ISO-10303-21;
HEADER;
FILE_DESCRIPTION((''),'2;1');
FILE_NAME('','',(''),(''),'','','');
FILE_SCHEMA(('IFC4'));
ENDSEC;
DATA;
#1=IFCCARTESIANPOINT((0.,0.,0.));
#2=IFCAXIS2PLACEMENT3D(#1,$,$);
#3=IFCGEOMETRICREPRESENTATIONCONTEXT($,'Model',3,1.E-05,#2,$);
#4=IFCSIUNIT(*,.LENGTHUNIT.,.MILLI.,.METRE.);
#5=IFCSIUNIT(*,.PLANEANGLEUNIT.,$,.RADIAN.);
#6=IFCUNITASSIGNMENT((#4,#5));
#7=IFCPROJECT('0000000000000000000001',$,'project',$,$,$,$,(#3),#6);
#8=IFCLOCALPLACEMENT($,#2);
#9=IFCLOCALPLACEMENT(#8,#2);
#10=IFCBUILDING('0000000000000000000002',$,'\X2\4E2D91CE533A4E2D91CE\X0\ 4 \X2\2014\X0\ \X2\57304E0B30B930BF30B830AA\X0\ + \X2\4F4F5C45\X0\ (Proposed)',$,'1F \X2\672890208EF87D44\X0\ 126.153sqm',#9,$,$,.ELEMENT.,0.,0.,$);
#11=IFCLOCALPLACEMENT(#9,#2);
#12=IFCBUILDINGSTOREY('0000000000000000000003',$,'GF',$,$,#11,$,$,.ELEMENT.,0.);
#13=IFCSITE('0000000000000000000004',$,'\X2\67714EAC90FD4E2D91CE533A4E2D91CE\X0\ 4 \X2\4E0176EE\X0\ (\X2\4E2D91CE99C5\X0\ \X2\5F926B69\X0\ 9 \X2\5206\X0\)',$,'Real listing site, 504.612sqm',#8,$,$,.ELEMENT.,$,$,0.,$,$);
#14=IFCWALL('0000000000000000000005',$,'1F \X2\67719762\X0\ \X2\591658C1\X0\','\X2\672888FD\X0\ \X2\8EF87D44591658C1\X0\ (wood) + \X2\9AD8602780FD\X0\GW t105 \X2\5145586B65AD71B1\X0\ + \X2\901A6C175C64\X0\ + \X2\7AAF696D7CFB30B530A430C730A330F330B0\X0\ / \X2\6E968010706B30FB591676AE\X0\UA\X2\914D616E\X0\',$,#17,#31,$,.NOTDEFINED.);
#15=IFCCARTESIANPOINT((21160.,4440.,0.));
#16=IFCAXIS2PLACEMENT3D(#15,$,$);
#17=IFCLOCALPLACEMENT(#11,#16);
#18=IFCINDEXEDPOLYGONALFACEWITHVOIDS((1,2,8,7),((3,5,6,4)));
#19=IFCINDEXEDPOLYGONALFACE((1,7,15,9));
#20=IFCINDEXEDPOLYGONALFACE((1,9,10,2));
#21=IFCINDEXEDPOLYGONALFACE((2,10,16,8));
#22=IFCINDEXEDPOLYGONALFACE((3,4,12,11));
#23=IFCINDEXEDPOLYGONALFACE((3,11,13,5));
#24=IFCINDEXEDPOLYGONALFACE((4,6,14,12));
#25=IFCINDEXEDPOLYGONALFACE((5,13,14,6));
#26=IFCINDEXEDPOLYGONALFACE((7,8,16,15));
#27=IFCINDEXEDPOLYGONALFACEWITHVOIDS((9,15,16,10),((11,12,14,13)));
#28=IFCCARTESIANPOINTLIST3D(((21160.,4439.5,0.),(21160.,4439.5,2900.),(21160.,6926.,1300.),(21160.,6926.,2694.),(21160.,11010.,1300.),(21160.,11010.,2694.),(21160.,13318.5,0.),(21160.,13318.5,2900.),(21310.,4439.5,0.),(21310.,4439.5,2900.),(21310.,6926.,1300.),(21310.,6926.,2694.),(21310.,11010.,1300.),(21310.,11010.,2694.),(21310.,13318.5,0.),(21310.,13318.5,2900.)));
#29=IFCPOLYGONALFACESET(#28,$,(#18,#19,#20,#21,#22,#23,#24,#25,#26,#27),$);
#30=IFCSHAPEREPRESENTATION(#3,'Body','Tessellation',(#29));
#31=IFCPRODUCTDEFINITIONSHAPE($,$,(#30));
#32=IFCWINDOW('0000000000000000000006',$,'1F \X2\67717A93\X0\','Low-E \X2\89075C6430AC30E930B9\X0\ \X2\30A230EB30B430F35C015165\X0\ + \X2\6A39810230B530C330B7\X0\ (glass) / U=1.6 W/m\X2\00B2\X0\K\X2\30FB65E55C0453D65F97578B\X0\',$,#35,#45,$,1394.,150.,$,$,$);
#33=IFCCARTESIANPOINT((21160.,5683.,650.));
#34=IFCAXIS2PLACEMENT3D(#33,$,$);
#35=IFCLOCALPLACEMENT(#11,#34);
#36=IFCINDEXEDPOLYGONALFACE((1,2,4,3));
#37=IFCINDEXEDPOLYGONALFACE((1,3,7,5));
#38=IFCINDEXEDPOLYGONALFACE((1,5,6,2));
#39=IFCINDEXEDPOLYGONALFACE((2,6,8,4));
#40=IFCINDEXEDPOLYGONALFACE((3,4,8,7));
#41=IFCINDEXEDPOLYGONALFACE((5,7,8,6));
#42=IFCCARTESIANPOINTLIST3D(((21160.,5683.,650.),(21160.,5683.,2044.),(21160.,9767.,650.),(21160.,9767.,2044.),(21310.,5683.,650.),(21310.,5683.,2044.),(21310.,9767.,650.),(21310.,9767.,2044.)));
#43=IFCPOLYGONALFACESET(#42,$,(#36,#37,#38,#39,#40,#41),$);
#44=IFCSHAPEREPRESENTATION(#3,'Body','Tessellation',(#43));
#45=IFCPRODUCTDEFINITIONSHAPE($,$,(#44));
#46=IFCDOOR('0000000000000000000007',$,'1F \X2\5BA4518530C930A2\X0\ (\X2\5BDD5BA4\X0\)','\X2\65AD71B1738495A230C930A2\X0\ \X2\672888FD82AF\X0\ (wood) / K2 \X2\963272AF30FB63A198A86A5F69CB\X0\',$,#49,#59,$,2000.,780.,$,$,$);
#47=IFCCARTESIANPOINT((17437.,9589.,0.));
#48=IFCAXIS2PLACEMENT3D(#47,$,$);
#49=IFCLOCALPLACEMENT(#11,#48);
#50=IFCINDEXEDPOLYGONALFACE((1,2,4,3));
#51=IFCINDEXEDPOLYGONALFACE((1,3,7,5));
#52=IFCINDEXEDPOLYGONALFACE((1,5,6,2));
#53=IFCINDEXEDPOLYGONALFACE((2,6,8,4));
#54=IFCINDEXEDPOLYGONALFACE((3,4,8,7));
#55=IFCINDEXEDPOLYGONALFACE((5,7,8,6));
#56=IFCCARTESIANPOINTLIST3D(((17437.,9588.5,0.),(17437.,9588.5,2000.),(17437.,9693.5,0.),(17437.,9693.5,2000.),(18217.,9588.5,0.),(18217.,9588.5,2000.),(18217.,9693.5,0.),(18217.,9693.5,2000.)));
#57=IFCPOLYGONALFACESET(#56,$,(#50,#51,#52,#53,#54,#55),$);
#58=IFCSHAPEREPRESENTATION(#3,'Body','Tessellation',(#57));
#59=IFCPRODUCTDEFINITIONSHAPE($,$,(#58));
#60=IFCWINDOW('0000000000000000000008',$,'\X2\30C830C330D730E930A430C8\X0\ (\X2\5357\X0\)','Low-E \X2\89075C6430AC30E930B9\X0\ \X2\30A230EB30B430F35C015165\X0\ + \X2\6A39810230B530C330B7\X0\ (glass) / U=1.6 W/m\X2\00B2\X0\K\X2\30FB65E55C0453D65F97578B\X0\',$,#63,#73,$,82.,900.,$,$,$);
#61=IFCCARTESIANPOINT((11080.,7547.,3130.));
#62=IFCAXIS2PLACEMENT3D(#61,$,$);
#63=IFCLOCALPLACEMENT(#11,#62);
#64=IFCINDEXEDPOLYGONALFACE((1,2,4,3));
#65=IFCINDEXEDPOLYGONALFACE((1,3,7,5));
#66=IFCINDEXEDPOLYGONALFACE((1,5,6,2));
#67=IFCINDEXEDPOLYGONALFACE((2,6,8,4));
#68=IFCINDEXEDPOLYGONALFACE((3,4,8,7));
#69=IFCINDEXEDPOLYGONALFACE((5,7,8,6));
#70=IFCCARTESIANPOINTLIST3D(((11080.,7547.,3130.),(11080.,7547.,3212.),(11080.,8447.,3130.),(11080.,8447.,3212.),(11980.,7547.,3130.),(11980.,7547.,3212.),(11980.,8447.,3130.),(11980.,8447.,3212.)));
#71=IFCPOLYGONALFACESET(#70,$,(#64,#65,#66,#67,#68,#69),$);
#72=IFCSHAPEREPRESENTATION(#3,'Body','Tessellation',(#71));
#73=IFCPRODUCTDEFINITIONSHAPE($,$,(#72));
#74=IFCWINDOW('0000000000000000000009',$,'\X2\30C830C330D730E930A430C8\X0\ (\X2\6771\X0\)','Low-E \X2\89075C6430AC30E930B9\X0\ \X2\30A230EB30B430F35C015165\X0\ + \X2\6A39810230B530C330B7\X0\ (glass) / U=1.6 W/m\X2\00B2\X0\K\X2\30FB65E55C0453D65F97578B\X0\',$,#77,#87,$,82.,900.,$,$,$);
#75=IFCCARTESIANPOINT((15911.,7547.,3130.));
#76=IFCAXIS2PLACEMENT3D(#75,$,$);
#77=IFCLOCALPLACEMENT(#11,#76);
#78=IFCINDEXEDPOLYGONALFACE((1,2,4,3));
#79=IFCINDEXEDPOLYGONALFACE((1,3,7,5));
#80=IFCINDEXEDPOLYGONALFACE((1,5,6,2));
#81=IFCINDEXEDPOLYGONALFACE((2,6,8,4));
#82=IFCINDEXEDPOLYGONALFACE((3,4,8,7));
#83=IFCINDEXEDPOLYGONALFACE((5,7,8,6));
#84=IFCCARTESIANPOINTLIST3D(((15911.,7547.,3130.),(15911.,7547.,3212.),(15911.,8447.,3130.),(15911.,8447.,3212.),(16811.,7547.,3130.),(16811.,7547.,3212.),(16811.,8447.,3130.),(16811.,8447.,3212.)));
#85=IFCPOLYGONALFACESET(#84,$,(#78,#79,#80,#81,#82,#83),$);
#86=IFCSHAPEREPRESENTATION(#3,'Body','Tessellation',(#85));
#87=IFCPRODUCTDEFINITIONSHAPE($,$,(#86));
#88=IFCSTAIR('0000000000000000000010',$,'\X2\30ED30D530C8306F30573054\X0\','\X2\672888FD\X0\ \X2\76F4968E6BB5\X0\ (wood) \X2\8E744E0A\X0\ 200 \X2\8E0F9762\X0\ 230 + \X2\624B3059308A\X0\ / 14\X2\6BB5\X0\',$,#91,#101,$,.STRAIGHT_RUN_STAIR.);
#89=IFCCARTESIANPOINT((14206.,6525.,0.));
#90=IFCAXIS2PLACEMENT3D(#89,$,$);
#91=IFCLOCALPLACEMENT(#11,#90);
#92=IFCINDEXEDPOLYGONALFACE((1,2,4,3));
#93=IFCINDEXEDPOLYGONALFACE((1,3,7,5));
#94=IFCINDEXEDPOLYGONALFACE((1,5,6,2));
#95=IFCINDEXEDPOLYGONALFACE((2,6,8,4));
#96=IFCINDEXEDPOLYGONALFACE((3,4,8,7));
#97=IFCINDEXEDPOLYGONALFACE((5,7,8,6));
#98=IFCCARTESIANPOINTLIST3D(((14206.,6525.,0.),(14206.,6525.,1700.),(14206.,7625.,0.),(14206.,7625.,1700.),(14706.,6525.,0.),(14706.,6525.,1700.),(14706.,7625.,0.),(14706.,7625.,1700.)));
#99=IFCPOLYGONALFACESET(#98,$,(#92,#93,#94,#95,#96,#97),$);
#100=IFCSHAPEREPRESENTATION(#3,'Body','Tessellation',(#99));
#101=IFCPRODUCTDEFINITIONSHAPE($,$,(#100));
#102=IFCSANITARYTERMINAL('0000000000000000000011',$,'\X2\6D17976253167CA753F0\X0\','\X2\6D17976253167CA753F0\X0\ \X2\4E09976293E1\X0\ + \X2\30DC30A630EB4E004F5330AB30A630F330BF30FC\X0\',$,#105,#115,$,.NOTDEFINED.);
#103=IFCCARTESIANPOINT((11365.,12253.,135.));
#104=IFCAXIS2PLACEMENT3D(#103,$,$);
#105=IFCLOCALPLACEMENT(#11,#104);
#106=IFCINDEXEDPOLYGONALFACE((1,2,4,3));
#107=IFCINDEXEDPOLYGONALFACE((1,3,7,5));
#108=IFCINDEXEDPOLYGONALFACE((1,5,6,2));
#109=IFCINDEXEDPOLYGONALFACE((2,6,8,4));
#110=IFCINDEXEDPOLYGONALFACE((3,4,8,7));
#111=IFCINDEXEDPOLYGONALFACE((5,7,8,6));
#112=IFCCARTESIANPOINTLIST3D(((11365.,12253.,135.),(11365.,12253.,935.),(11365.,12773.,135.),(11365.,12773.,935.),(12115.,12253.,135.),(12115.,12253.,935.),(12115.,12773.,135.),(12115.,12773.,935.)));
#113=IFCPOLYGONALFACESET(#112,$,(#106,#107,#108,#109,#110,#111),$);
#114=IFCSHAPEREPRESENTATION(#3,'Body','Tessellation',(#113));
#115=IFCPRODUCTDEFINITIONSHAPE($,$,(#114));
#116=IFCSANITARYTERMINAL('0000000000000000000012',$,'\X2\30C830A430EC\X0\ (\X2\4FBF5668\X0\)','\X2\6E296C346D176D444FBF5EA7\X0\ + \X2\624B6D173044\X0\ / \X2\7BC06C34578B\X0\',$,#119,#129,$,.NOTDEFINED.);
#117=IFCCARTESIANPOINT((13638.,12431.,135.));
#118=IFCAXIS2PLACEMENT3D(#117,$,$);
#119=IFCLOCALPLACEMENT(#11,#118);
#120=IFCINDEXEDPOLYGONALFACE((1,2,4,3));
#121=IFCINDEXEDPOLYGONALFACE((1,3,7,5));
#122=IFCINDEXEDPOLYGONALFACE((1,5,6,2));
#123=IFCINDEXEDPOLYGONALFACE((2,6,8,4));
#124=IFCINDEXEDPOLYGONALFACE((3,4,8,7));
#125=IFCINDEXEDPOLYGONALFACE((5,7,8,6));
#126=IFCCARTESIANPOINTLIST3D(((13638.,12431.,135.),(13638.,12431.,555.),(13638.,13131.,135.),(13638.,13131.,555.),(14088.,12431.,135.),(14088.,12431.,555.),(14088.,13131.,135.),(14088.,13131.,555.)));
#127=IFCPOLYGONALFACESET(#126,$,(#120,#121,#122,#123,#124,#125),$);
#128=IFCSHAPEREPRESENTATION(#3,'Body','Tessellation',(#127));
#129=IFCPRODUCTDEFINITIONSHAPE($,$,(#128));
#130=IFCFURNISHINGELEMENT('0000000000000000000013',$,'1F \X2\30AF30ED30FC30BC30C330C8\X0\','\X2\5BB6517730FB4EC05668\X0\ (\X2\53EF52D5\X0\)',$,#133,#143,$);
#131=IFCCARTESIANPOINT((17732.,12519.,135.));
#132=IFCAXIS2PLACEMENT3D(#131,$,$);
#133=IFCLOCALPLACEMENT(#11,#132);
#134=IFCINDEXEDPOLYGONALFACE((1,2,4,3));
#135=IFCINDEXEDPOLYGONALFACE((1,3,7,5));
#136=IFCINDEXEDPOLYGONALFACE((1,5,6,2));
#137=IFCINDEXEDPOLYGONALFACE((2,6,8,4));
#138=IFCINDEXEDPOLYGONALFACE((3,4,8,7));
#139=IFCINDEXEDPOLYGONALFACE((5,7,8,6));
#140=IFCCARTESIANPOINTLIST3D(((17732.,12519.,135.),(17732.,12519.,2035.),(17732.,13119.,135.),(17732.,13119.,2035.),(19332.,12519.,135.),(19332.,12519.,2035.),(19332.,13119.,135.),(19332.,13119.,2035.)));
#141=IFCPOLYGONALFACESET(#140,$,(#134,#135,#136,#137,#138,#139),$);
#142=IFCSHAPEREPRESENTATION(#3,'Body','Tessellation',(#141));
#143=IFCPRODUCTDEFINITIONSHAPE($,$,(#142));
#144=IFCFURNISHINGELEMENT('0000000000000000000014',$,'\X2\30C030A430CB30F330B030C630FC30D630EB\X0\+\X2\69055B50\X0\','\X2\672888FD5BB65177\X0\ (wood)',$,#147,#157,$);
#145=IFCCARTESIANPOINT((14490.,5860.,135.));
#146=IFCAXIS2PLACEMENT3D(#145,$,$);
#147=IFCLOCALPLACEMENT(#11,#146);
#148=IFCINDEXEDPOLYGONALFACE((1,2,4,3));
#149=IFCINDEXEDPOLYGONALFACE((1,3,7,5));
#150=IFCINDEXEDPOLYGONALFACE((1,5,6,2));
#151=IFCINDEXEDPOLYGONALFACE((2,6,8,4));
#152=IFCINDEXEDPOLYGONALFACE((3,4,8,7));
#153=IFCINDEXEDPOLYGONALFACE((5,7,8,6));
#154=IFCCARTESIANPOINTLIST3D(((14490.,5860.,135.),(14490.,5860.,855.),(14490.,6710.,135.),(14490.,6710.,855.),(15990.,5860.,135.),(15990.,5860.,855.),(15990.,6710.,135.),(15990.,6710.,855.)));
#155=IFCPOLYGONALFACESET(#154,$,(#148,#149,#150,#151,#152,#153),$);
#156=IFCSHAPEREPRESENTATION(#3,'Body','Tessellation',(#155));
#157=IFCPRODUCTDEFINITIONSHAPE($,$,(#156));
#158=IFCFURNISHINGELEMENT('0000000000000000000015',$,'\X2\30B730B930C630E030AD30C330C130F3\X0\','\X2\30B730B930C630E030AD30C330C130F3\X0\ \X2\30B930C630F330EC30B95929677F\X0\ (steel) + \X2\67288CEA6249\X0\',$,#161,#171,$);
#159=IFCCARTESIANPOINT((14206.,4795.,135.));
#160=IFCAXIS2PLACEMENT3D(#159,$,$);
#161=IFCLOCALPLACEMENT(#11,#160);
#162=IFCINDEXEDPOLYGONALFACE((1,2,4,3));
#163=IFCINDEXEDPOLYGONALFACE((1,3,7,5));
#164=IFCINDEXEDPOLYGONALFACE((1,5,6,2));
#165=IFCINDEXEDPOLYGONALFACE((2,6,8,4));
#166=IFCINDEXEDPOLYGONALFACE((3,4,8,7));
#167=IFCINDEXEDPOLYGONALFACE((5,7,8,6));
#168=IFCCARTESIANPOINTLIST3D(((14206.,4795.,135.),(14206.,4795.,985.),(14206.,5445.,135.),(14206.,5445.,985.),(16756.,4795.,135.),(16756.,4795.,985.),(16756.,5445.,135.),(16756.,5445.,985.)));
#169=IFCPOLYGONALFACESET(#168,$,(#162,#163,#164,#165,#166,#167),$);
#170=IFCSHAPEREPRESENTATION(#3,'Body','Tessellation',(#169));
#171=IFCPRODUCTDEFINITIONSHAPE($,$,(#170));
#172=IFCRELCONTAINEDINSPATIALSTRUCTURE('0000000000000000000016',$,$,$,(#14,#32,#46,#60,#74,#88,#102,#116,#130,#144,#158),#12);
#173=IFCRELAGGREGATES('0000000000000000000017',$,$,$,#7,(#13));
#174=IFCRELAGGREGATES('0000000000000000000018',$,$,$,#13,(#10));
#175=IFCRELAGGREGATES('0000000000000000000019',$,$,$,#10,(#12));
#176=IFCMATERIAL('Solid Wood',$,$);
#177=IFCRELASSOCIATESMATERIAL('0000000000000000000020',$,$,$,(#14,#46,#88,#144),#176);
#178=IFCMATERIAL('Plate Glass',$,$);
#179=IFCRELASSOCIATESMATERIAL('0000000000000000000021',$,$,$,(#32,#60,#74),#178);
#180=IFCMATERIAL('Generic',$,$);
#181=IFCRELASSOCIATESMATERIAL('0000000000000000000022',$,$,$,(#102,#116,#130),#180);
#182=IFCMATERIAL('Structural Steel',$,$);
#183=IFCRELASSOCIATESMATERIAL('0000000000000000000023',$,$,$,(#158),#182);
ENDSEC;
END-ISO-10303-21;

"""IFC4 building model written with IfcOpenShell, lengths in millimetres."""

from ifc_helpers import new_model, si_unit, frame, frame_2d, origin, place, context, project, spatial, rectangle, extrude, material, element, fill, save


model = new_model("IFC4")

# Units and contexts
model_context = context("Model", 3, precision=1e-05, world=origin())
ifc_project = project(units=[si_unit("LENGTHUNIT", "METRE", prefix="MILLI"), si_unit("PLANEANGLEUNIT", "RADIAN")], contexts=[model_context])

# Site, building, storey
site_placement = place(None, origin())
site = spatial("IfcSite", under=ifc_project, at=site_placement, Name="東京都中野区中野 4 丁目 (中野駅 徒歩 9 分)", ObjectType="Real listing site, 504.612sqm", CompositionType="ELEMENT", RefElevation=0.0)
building_placement = place(site_placement, origin())
building = spatial("IfcBuilding", under=site, at=building_placement, Name="中野区中野 4 — 地下スタジオ + 住居 (Proposed)", ObjectType="1F 木造軸組 126.153sqm", CompositionType="ELEMENT", ElevationOfRefHeight=0.0, ElevationOfTerrain=0.0)
storey_placement = place(building_placement, origin())
storey = spatial("IfcBuildingStorey", under=building, at=storey_placement, Name="GF", CompositionType="ELEMENT", Elevation=0.0)

# Wall, opening, window
ifc_material_1 = material(Name="Solid Wood")
wall_1_placement = place(storey_placement, frame((21160.0, 4440.0, 0.0)))
wall_1 = element("IfcWall", 1, at=wall_1_placement, inside=storey, material=ifc_material_1, Name="1F 東面 外壁", Description="木製 軸組外壁 (wood) + 高性能GW t105 充填断熱 + 通気層 + 窯業系サイディング / 準耐火・外皮UA配慮", PredefinedType="NOTDEFINED", context=model_context, shape_type="SweptSolid", body=[
    extrude(rectangle(XDim=150.0, YDim=8879.0, at=frame_2d((75.0, 4439.0))), frame((21160.0, 4440.0, 0.0)), (0.0, 0.0, 1.0), 2900.0),
])
opening_placement = place(storey_placement, frame((21160.0, 5683.0, 650.0)))
opening = element("IfcOpeningElement", 2, at=opening_placement, cuts=wall_1, PredefinedType="NOTDEFINED", context=model_context, shape_type="SweptSolid", body=[
    extrude(rectangle(XDim=150.0, YDim=4084.0, at=frame_2d((75.0, 2042.0))), frame((21160.0, 5683.0, 650.0)), (0.0, 0.0, 1.0), 1394.0),
])
ifc_material_2 = material(Name="Plate Glass")
window_1_placement = place(storey_placement, frame((21160.0, 5683.0, 650.0)))
window_1 = element("IfcWindow", 3, at=window_1_placement, inside=storey, material=ifc_material_2, Name="1F 東窓", Description="Low-E 複層ガラス アルゴン封入 + 樹脂サッシ (glass) / U=1.6 W/m²K・日射取得型", OverallHeight=1394.0, OverallWidth=150.0, context=model_context, shape_type="SweptSolid", body=[
    extrude(rectangle(XDim=150.0, YDim=4084.0, at=frame_2d((75.0, 2042.0))), frame((21160.0, 5683.0, 650.0)), (0.0, 0.0, 1.0), 1394.0),
])
fill(opening, window_1)

# Door
door_placement = place(storey_placement, frame((17437.0, 9589.0, 0.0)))
element("IfcDoor", 4, at=door_placement, inside=storey, material=ifc_material_1, Name="1F 室内ドア (寝室)", Description="断熱玄関ドア 木製芯 (wood) / K2 防犯・採風機構", OverallHeight=2000.0, OverallWidth=780.0, context=model_context, shape_type="SweptSolid", body=[
    extrude(rectangle(XDim=780.0, YDim=105.0, at=frame_2d((390.0, 52.0))), frame((17437.0, 9589.0, 0.0)), (0.0, 0.0, 1.0), 2000.0),
])

# Windows
window_2_placement = place(storey_placement, frame((11080.0, 7547.0, 3130.0)))
element("IfcWindow", 5, at=window_2_placement, inside=storey, material=ifc_material_2, Name="トップライト (南)", Description="Low-E 複層ガラス アルゴン封入 + 樹脂サッシ (glass) / U=1.6 W/m²K・日射取得型", OverallHeight=82.0, OverallWidth=900.0, context=model_context, shape_type="SweptSolid", body=[
    extrude(rectangle(XDim=900.0, YDim=900.0, at=frame_2d((450.0, 450.0))), frame((11080.0, 7547.0, 3130.0)), (0.0, 0.0, 1.0), 82.0),
])
window_3_placement = place(storey_placement, frame((15911.0, 7547.0, 3130.0)))
element("IfcWindow", 6, at=window_3_placement, inside=storey, material=ifc_material_2, Name="トップライト (東)", Description="Low-E 複層ガラス アルゴン封入 + 樹脂サッシ (glass) / U=1.6 W/m²K・日射取得型", OverallHeight=82.0, OverallWidth=900.0, context=model_context, shape_type="SweptSolid", body=[
    extrude(rectangle(XDim=900.0, YDim=900.0, at=frame_2d((450.0, 450.0))), frame((15911.0, 7547.0, 3130.0)), (0.0, 0.0, 1.0), 82.0),
])

# Stair
stair_placement = place(storey_placement, frame((14206.0, 6525.0, 0.0)))
element("IfcStair", 7, at=stair_placement, inside=storey, material=ifc_material_1, Name="ロフトはしご", Description="木製 直階段 (wood) 蹴上 200 踏面 230 + 手すり / 14段", PredefinedType="STRAIGHT_RUN_STAIR", context=model_context, shape_type="SweptSolid", body=[
    extrude(rectangle(XDim=500.0, YDim=1100.0, at=frame_2d((250.0, 550.0))), frame((14206.0, 6525.0, 0.0)), (0.0, 0.0, 1.0), 1700.0),
])

# Sanitary terminals
ifc_material_3 = material(Name="Generic")
sanitary_terminal_1_placement = place(storey_placement, frame((11365.0, 12253.0, 135.0)))
element("IfcSanitaryTerminal", 8, at=sanitary_terminal_1_placement, inside=storey, material=ifc_material_3, Name="洗面化粧台", Description="洗面化粧台 三面鏡 + ボウル一体カウンター", PredefinedType="NOTDEFINED", context=model_context, shape_type="SweptSolid", body=[
    extrude(rectangle(XDim=750.0, YDim=520.0, at=frame_2d((375.0, 260.0))), frame((11365.0, 12253.0, 135.0)), (0.0, 0.0, 1.0), 800.0),
])
sanitary_terminal_2_placement = place(storey_placement, frame((13638.0, 12431.0, 135.0)))
element("IfcSanitaryTerminal", 9, at=sanitary_terminal_2_placement, inside=storey, material=ifc_material_3, Name="トイレ (便器)", Description="温水洗浄便座 + 手洗い / 節水型", PredefinedType="NOTDEFINED", context=model_context, shape_type="SweptSolid", body=[
    extrude(rectangle(XDim=450.0, YDim=700.0, at=frame_2d((225.0, 350.0))), frame((13638.0, 12431.0, 135.0)), (0.0, 0.0, 1.0), 420.0),
])

# Furnishing elements
furnishing_1_placement = place(storey_placement, frame((17732.0, 12519.0, 135.0)))
element("IfcFurnishingElement", 10, at=furnishing_1_placement, inside=storey, material=ifc_material_3, Name="1F クローゼット", Description="家具・什器 (可動)", context=model_context, shape_type="SweptSolid", body=[
    extrude(rectangle(XDim=1600.0, YDim=600.0, at=frame_2d((800.0, 300.0))), frame((17732.0, 12519.0, 135.0)), (0.0, 0.0, 1.0), 1900.0),
])
furnishing_2_placement = place(storey_placement, frame((14490.0, 5860.0, 135.0)))
element("IfcFurnishingElement", 11, at=furnishing_2_placement, inside=storey, material=ifc_material_1, Name="ダイニングテーブル+椅子", Description="木製家具 (wood)", context=model_context, shape_type="SweptSolid", body=[
    extrude(rectangle(XDim=1500.0, YDim=850.0, at=frame_2d((750.0, 425.0))), frame((14490.0, 5860.0, 135.0)), (0.0, 0.0, 1.0), 720.0),
])
ifc_material_4 = material(Name="Structural Steel")
furnishing_3_placement = place(storey_placement, frame((14206.0, 4795.0, 135.0)))
element("IfcFurnishingElement", 12, at=furnishing_3_placement, inside=storey, material=ifc_material_4, Name="システムキッチン", Description="システムキッチン ステンレス天板 (steel) + 木質扉", context=model_context, shape_type="SweptSolid", body=[
    extrude(rectangle(XDim=2550.0, YDim=650.0, at=frame_2d((1275.0, 325.0))), frame((14206.0, 4795.0, 135.0)), (0.0, 0.0, 1.0), 850.0),
])

save(model, "model.ifc")
